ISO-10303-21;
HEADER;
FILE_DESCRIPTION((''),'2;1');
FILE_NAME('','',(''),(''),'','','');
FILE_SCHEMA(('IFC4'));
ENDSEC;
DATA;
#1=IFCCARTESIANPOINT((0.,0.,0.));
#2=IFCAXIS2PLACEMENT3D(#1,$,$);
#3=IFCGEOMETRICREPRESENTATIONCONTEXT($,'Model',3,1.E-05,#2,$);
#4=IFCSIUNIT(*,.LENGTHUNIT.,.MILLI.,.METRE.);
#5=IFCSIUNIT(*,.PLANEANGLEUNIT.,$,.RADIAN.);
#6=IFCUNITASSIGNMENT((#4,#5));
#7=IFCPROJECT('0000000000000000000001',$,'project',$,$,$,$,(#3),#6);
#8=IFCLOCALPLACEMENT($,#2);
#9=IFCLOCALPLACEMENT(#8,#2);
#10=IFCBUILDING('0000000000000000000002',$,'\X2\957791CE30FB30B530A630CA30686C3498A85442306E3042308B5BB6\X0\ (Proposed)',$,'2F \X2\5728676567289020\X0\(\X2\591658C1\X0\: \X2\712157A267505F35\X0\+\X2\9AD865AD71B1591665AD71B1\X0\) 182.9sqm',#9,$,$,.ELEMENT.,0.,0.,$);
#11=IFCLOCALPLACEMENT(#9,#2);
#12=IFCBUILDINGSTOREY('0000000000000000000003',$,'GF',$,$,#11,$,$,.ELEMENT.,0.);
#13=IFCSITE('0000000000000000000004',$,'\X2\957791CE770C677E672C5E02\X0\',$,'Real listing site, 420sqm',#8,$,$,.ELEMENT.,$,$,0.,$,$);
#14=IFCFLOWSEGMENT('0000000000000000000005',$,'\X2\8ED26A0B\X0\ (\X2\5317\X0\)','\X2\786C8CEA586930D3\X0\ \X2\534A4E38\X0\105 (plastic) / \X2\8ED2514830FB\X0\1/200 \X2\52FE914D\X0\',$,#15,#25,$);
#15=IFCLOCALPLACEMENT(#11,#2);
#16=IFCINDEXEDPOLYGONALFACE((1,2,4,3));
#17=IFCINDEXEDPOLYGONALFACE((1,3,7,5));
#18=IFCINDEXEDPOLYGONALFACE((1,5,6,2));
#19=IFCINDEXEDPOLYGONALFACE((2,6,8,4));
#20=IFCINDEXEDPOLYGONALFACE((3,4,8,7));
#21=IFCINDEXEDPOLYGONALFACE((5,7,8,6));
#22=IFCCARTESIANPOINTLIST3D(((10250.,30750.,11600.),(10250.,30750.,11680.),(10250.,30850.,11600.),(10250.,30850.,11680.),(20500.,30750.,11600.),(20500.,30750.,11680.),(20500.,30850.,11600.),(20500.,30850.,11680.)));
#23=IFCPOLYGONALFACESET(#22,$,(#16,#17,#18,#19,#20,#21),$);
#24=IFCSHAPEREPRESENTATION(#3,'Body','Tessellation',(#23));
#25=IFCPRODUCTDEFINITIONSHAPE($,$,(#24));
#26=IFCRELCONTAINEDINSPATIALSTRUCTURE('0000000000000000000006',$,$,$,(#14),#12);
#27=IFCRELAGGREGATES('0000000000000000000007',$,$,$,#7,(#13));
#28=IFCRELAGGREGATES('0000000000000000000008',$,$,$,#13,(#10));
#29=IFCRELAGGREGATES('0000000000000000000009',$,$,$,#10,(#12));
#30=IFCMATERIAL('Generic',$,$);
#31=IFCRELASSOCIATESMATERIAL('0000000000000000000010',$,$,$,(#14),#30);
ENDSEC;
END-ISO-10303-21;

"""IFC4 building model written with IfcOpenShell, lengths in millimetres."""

from ifc_helpers import new_model, si_unit, frame, frame_2d, origin, place, context, project, spatial, rectangle, extrude, material, element, save


model = new_model("IFC4")

# Units and contexts
model_context = context("Model", 3, precision=1e-05, world=origin())
ifc_project = project(units=[si_unit("LENGTHUNIT", "METRE", prefix="MILLI"), si_unit("PLANEANGLEUNIT", "RADIAN")], contexts=[model_context])

# Site, building, storey
site_placement = place(None, origin())
site = spatial("IfcSite", under=ifc_project, at=site_placement, Name="長野県松本市", ObjectType="Real listing site, 420sqm", CompositionType="ELEMENT", RefElevation=0.0)
building_placement = place(site_placement, origin())
building = spatial("IfcBuilding", under=site, at=building_placement, Name="長野・サウナと水風呂のある家 (Proposed)", ObjectType="2F 在来木造(外壁: 無垢材張+高断熱外断熱) 182.9sqm", CompositionType="ELEMENT", ElevationOfRefHeight=0.0, ElevationOfTerrain=0.0)
storey_placement = place(building_placement, origin())
storey = spatial("IfcBuildingStorey", under=building, at=storey_placement, Name="GF", CompositionType="ELEMENT", Elevation=0.0)

# Shared definitions
ifc_material_1 = material(Name="Generic")

# Flow segment
flow_segment_placement = place(storey_placement, frame((5125.0, 15375.0, 5800.0)))
element("IfcFlowSegment", 1, at=flow_segment_placement, inside=storey, material=ifc_material_1, Name="軒樋 (北)", Description="硬質塩ビ 半丸105 (plastic) / 軒先・1/200 勾配", context=model_context, shape_type="SweptSolid", body=[
    extrude(rectangle(XDim=10250.0, YDim=100.0, at=frame_2d((5125.0, 50.0))), frame((5125.0, 15375.0, 5800.0)), (0.0, 0.0, 1.0), 80.0),
])

save(model, "model.ifc")
